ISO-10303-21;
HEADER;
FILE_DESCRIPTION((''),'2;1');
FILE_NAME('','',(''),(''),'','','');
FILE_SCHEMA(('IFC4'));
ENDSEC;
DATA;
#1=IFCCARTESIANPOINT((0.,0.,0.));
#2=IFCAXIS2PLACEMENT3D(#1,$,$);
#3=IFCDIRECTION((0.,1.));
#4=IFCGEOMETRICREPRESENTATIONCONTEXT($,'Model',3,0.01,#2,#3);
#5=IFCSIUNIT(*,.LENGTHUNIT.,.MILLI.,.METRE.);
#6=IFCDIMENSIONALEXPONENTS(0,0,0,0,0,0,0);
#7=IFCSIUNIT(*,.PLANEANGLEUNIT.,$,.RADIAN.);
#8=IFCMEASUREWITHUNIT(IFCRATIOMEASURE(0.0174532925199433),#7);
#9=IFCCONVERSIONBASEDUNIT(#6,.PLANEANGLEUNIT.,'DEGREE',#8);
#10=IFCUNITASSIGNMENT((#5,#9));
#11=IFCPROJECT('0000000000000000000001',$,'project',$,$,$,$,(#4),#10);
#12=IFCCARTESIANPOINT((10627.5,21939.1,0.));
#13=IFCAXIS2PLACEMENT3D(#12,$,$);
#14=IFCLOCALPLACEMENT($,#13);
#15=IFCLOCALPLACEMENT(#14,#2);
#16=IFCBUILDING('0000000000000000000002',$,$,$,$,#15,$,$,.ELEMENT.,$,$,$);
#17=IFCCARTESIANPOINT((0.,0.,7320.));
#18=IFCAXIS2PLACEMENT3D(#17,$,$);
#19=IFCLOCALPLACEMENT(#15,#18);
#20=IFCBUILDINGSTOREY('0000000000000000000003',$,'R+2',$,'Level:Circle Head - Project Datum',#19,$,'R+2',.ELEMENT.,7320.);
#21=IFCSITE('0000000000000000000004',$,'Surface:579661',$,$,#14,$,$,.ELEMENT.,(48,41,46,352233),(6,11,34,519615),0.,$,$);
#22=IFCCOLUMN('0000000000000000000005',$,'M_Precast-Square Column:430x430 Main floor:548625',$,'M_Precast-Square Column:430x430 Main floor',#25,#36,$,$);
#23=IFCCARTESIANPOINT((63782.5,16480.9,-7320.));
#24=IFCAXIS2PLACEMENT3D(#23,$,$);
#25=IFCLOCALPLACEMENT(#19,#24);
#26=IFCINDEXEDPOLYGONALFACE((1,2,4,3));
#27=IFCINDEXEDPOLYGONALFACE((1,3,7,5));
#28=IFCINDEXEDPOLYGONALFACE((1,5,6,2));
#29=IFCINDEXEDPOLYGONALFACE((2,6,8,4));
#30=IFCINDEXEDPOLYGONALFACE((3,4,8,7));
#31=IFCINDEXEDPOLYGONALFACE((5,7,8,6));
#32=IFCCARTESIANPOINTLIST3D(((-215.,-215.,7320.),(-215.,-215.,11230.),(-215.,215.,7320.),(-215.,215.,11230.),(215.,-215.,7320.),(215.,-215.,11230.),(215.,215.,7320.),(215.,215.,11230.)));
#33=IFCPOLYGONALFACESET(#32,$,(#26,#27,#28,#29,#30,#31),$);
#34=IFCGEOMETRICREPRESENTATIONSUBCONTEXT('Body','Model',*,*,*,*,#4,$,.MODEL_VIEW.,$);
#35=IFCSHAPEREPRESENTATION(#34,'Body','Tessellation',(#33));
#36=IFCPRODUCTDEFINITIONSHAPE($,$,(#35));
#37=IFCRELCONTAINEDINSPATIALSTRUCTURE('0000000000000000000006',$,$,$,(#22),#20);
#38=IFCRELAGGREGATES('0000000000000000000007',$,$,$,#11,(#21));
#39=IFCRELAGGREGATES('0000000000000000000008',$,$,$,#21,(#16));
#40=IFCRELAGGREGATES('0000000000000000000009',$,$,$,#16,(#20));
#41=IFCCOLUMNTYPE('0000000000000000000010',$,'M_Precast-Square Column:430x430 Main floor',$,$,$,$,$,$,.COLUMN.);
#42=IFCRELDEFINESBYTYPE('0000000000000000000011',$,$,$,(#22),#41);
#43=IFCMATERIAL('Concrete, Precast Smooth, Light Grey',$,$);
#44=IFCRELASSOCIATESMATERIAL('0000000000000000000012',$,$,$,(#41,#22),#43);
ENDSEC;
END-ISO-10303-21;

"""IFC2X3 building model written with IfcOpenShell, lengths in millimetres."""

from ifc_helpers import new_model, entity, si_unit, converted_unit, direction, frame, origin, origin_2d_with_axis, place, context, subcontext, project, spatial, rectangle, extrude, source, transform, mapped, material, type_object, type_shapes, element, save


model = new_model("IFC2X3")

# Units and contexts
model_context = context("Model", 3, precision=0.01, world=origin(), true_north=direction((0.0, 1.0)))
body_context = subcontext(model_context, "Body", "Model", "MODEL_VIEW")
ifc_project = project(units=[si_unit("LENGTHUNIT", "METRE", prefix="MILLI"), converted_unit("PLANEANGLEUNIT", "DEGREE", entity("IfcRatioMeasure", 0.0174532925199433), si_unit("PLANEANGLEUNIT", "RADIAN"), dimensions=[0, 0, 0, 0, 0, 0, 0])], contexts=[model_context])

# Site, building, storey
site_placement = place(None, frame((10627.5, 21939.1, 0.0)))
site = spatial("IfcSite", under=ifc_project, at=site_placement, Name="Surface:579661", CompositionType="ELEMENT", RefLatitude=(48, 41, 46, 352233), RefLongitude=(6, 11, 34, 519615), RefElevation=0.0)
building_placement = place(site_placement, origin())
building = spatial("IfcBuilding", under=site, at=building_placement, CompositionType="ELEMENT")
storey_placement = place(building_placement, frame((0.0, 0.0, 7320.0)))
storey = spatial("IfcBuildingStorey", under=building, at=storey_placement, Name="R+2", ObjectType="Level:Circle Head - Project Datum", LongName="R+2", CompositionType="ELEMENT", Elevation=7320.0)

# Column
ifc_material = material(Name="Concrete, Precast Smooth, Light Grey")
column_type = type_object("IfcColumnType", Name="M_Precast-Square Column:430x430 Main floor", PredefinedType="COLUMN", material=ifc_material)
shared_shape = source(origin(), body_context, "Body", "SweptSolid", [
    extrude(rectangle(XDim=430.0, YDim=430.0, at=origin_2d_with_axis()), frame((0.0, 0.0, 7320.0), z_axis=(0.0, 0.0, 1.0), x_axis=(0.0, -1.0, 0.0)), (0.0, 0.0, 1.0), 3910.0),
])
type_shapes(column_type, [shared_shape])
column_placement = place(storey_placement, frame((63782.5, 16480.9, -7320.0)))
element("IfcColumn", 1, at=column_placement, inside=storey, type_object=column_type, material=ifc_material, Name="M_Precast-Square Column:430x430 Main floor:548625", ObjectType="M_Precast-Square Column:430x430 Main floor", context=body_context, shape_type="MappedRepresentation", body=[
    mapped(shared_shape, transform((0.0, 0.0, 0.0), scale=1.0)),
])

save(model, "model.ifc")
